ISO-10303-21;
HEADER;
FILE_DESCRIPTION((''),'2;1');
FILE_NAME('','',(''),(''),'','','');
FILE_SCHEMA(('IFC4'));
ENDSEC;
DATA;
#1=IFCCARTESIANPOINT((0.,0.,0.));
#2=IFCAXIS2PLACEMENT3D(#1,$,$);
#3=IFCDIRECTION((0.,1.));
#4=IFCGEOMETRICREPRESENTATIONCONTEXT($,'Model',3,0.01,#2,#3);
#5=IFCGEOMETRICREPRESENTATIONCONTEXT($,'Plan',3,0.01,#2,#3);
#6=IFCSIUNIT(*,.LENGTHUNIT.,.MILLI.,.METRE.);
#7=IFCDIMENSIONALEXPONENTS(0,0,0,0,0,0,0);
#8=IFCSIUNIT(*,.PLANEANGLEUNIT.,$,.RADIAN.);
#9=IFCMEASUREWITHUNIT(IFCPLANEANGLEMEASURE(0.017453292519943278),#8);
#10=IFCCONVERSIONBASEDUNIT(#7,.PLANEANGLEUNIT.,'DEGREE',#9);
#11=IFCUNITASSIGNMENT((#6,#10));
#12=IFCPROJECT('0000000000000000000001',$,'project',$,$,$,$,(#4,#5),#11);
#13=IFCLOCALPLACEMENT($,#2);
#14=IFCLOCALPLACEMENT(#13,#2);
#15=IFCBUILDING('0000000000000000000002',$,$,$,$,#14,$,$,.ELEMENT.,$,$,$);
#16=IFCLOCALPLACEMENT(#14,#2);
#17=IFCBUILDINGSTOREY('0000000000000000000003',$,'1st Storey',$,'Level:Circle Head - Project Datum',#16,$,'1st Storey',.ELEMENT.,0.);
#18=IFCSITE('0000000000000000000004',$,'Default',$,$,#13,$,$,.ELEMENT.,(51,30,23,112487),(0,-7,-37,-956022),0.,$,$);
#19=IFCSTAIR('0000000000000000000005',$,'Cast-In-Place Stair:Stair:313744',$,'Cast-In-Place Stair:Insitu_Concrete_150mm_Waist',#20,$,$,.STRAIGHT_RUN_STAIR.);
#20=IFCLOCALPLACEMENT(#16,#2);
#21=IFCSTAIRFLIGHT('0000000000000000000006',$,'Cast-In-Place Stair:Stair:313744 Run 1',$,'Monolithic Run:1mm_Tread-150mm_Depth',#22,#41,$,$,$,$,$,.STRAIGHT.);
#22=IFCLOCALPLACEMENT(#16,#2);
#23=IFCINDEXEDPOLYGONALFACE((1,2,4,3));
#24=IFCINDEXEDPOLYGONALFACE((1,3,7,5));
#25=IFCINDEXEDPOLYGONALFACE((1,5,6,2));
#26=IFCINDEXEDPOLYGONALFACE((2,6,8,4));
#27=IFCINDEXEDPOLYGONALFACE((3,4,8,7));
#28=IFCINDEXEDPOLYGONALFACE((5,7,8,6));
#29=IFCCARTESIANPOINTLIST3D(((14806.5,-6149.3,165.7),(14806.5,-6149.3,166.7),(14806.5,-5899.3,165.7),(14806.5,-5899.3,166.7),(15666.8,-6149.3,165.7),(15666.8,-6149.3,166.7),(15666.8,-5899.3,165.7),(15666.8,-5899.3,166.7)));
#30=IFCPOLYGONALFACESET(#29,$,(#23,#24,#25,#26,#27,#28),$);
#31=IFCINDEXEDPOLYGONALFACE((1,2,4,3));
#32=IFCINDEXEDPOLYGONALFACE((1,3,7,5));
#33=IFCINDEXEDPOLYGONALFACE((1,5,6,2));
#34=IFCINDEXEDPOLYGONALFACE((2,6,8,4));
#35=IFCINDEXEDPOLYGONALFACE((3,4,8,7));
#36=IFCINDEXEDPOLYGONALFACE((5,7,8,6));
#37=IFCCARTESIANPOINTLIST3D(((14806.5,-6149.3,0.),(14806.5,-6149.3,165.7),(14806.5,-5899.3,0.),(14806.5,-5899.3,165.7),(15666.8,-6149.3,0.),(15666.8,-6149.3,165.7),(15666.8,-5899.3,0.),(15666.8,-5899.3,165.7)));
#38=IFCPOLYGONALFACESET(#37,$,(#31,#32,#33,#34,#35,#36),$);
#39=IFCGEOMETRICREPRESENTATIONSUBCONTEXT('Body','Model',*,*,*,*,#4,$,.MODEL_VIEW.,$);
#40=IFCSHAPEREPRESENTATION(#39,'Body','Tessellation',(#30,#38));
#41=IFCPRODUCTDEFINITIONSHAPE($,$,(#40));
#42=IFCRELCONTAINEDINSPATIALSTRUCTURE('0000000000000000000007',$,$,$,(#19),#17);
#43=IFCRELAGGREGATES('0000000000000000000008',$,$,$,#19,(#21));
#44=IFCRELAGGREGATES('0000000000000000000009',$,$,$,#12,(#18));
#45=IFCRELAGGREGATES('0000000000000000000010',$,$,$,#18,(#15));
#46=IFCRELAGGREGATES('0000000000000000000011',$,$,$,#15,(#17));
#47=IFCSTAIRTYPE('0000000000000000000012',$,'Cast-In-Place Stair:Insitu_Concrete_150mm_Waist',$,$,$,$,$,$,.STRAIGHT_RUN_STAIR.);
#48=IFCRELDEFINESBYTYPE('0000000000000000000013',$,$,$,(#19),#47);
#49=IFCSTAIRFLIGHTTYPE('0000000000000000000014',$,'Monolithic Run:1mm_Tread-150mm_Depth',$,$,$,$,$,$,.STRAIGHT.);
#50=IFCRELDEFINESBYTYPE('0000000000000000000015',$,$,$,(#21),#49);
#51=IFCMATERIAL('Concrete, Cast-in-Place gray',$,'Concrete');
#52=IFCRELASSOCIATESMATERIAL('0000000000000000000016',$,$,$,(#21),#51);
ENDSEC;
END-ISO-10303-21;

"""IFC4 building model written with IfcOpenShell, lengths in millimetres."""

from ifc_helpers import new_model, entity, si_unit, converted_unit, direction, frame, origin, place, context, subcontext, project, spatial, indexed_curve, outline, extrude, material, type_object, element, aggregate, save


model = new_model("IFC4")

# Units and contexts
model_context = context("Model", 3, precision=0.01, world=origin(), true_north=direction((0.0, 1.0)))
plan_context = context("Plan", 3, precision=0.01, world=origin(), true_north=direction((0.0, 1.0)))
body_context = subcontext(model_context, "Body", "Model", "MODEL_VIEW")
ifc_project = project(units=[si_unit("LENGTHUNIT", "METRE", prefix="MILLI"), converted_unit("PLANEANGLEUNIT", "DEGREE", entity("IfcPlaneAngleMeasure", 0.017453292519943278), si_unit("PLANEANGLEUNIT", "RADIAN"), dimensions=[0, 0, 0, 0, 0, 0, 0])], contexts=[model_context, plan_context])

# Site, building, storey
site_placement = place(None, origin())
site = spatial("IfcSite", under=ifc_project, at=site_placement, Name="Default", CompositionType="ELEMENT", RefLatitude=(51, 30, 23, 112487), RefLongitude=(0, -7, -37, -956022), RefElevation=0.0)
building_placement = place(site_placement, origin())
building = spatial("IfcBuilding", under=site, at=building_placement, CompositionType="ELEMENT")
storey_placement = place(building_placement, origin())
storey = spatial("IfcBuildingStorey", under=building, at=storey_placement, Name="1st Storey", ObjectType="Level:Circle Head - Project Datum", LongName="1st Storey", CompositionType="ELEMENT", Elevation=0.0)

# Shared definitions
ifc_material_1 = material(Name="Concrete, Cast-in-Place gray", Category="Concrete")

# Stair, stair flight
stair_type_1 = type_object("IfcStairType", Name="Cast-In-Place Stair:Insitu_Concrete_150mm_Waist", PredefinedType="STRAIGHT_RUN_STAIR")
stair_1_placement = place(storey_placement, origin())
stair_1 = element("IfcStair", 1, at=stair_1_placement, inside=storey, type_object=stair_type_1, Name="Cast-In-Place Stair:Stair:313744", ObjectType="Cast-In-Place Stair:Insitu_Concrete_150mm_Waist", PredefinedType="STRAIGHT_RUN_STAIR")
stair_flight_type = type_object("IfcStairFlightType", Name="Monolithic Run:1mm_Tread-150mm_Depth", PredefinedType="STRAIGHT")
stair_flight_placement = place(stair_1_placement, frame((14806.5, -6149.3, 0.0)))
stair_flight = element("IfcStairFlight", 2, at=stair_flight_placement, type_object=stair_flight_type, material=ifc_material_1, Name="Cast-In-Place Stair:Stair:313744 Run 1", ObjectType="Monolithic Run:1mm_Tread-150mm_Depth", PredefinedType="STRAIGHT", context=body_context, shape_type="SweptSolid", body=[
    extrude(outline(indexed_curve([(-125.0, -430.2), (125.0, -430.2), (125.0, 430.2), (-125.0, 430.2), (-125.0, -430.2)], self_intersect=False)), frame((430.2, 125.0, 165.7), z_axis=(0.0, 0.0, 1.0), x_axis=(0.0, -1.0, 0.0)), (0.0, 0.0, 1.0), 1.0),
    extrude(outline(indexed_curve([(-82.8, -125.0), (82.8, -125.0), (82.8, 125.0), (-82.8, 125.0), (-82.8, -125.0)], self_intersect=False)), frame((0.0, 125.0, 82.8), z_axis=(1.0, 0.0, 0.0), x_axis=(0.0, 0.0, -1.0)), (0.0, 0.0, 1.0), 860.3),
])
aggregate(stair_1, [stair_flight])

save(model, "model.ifc")
